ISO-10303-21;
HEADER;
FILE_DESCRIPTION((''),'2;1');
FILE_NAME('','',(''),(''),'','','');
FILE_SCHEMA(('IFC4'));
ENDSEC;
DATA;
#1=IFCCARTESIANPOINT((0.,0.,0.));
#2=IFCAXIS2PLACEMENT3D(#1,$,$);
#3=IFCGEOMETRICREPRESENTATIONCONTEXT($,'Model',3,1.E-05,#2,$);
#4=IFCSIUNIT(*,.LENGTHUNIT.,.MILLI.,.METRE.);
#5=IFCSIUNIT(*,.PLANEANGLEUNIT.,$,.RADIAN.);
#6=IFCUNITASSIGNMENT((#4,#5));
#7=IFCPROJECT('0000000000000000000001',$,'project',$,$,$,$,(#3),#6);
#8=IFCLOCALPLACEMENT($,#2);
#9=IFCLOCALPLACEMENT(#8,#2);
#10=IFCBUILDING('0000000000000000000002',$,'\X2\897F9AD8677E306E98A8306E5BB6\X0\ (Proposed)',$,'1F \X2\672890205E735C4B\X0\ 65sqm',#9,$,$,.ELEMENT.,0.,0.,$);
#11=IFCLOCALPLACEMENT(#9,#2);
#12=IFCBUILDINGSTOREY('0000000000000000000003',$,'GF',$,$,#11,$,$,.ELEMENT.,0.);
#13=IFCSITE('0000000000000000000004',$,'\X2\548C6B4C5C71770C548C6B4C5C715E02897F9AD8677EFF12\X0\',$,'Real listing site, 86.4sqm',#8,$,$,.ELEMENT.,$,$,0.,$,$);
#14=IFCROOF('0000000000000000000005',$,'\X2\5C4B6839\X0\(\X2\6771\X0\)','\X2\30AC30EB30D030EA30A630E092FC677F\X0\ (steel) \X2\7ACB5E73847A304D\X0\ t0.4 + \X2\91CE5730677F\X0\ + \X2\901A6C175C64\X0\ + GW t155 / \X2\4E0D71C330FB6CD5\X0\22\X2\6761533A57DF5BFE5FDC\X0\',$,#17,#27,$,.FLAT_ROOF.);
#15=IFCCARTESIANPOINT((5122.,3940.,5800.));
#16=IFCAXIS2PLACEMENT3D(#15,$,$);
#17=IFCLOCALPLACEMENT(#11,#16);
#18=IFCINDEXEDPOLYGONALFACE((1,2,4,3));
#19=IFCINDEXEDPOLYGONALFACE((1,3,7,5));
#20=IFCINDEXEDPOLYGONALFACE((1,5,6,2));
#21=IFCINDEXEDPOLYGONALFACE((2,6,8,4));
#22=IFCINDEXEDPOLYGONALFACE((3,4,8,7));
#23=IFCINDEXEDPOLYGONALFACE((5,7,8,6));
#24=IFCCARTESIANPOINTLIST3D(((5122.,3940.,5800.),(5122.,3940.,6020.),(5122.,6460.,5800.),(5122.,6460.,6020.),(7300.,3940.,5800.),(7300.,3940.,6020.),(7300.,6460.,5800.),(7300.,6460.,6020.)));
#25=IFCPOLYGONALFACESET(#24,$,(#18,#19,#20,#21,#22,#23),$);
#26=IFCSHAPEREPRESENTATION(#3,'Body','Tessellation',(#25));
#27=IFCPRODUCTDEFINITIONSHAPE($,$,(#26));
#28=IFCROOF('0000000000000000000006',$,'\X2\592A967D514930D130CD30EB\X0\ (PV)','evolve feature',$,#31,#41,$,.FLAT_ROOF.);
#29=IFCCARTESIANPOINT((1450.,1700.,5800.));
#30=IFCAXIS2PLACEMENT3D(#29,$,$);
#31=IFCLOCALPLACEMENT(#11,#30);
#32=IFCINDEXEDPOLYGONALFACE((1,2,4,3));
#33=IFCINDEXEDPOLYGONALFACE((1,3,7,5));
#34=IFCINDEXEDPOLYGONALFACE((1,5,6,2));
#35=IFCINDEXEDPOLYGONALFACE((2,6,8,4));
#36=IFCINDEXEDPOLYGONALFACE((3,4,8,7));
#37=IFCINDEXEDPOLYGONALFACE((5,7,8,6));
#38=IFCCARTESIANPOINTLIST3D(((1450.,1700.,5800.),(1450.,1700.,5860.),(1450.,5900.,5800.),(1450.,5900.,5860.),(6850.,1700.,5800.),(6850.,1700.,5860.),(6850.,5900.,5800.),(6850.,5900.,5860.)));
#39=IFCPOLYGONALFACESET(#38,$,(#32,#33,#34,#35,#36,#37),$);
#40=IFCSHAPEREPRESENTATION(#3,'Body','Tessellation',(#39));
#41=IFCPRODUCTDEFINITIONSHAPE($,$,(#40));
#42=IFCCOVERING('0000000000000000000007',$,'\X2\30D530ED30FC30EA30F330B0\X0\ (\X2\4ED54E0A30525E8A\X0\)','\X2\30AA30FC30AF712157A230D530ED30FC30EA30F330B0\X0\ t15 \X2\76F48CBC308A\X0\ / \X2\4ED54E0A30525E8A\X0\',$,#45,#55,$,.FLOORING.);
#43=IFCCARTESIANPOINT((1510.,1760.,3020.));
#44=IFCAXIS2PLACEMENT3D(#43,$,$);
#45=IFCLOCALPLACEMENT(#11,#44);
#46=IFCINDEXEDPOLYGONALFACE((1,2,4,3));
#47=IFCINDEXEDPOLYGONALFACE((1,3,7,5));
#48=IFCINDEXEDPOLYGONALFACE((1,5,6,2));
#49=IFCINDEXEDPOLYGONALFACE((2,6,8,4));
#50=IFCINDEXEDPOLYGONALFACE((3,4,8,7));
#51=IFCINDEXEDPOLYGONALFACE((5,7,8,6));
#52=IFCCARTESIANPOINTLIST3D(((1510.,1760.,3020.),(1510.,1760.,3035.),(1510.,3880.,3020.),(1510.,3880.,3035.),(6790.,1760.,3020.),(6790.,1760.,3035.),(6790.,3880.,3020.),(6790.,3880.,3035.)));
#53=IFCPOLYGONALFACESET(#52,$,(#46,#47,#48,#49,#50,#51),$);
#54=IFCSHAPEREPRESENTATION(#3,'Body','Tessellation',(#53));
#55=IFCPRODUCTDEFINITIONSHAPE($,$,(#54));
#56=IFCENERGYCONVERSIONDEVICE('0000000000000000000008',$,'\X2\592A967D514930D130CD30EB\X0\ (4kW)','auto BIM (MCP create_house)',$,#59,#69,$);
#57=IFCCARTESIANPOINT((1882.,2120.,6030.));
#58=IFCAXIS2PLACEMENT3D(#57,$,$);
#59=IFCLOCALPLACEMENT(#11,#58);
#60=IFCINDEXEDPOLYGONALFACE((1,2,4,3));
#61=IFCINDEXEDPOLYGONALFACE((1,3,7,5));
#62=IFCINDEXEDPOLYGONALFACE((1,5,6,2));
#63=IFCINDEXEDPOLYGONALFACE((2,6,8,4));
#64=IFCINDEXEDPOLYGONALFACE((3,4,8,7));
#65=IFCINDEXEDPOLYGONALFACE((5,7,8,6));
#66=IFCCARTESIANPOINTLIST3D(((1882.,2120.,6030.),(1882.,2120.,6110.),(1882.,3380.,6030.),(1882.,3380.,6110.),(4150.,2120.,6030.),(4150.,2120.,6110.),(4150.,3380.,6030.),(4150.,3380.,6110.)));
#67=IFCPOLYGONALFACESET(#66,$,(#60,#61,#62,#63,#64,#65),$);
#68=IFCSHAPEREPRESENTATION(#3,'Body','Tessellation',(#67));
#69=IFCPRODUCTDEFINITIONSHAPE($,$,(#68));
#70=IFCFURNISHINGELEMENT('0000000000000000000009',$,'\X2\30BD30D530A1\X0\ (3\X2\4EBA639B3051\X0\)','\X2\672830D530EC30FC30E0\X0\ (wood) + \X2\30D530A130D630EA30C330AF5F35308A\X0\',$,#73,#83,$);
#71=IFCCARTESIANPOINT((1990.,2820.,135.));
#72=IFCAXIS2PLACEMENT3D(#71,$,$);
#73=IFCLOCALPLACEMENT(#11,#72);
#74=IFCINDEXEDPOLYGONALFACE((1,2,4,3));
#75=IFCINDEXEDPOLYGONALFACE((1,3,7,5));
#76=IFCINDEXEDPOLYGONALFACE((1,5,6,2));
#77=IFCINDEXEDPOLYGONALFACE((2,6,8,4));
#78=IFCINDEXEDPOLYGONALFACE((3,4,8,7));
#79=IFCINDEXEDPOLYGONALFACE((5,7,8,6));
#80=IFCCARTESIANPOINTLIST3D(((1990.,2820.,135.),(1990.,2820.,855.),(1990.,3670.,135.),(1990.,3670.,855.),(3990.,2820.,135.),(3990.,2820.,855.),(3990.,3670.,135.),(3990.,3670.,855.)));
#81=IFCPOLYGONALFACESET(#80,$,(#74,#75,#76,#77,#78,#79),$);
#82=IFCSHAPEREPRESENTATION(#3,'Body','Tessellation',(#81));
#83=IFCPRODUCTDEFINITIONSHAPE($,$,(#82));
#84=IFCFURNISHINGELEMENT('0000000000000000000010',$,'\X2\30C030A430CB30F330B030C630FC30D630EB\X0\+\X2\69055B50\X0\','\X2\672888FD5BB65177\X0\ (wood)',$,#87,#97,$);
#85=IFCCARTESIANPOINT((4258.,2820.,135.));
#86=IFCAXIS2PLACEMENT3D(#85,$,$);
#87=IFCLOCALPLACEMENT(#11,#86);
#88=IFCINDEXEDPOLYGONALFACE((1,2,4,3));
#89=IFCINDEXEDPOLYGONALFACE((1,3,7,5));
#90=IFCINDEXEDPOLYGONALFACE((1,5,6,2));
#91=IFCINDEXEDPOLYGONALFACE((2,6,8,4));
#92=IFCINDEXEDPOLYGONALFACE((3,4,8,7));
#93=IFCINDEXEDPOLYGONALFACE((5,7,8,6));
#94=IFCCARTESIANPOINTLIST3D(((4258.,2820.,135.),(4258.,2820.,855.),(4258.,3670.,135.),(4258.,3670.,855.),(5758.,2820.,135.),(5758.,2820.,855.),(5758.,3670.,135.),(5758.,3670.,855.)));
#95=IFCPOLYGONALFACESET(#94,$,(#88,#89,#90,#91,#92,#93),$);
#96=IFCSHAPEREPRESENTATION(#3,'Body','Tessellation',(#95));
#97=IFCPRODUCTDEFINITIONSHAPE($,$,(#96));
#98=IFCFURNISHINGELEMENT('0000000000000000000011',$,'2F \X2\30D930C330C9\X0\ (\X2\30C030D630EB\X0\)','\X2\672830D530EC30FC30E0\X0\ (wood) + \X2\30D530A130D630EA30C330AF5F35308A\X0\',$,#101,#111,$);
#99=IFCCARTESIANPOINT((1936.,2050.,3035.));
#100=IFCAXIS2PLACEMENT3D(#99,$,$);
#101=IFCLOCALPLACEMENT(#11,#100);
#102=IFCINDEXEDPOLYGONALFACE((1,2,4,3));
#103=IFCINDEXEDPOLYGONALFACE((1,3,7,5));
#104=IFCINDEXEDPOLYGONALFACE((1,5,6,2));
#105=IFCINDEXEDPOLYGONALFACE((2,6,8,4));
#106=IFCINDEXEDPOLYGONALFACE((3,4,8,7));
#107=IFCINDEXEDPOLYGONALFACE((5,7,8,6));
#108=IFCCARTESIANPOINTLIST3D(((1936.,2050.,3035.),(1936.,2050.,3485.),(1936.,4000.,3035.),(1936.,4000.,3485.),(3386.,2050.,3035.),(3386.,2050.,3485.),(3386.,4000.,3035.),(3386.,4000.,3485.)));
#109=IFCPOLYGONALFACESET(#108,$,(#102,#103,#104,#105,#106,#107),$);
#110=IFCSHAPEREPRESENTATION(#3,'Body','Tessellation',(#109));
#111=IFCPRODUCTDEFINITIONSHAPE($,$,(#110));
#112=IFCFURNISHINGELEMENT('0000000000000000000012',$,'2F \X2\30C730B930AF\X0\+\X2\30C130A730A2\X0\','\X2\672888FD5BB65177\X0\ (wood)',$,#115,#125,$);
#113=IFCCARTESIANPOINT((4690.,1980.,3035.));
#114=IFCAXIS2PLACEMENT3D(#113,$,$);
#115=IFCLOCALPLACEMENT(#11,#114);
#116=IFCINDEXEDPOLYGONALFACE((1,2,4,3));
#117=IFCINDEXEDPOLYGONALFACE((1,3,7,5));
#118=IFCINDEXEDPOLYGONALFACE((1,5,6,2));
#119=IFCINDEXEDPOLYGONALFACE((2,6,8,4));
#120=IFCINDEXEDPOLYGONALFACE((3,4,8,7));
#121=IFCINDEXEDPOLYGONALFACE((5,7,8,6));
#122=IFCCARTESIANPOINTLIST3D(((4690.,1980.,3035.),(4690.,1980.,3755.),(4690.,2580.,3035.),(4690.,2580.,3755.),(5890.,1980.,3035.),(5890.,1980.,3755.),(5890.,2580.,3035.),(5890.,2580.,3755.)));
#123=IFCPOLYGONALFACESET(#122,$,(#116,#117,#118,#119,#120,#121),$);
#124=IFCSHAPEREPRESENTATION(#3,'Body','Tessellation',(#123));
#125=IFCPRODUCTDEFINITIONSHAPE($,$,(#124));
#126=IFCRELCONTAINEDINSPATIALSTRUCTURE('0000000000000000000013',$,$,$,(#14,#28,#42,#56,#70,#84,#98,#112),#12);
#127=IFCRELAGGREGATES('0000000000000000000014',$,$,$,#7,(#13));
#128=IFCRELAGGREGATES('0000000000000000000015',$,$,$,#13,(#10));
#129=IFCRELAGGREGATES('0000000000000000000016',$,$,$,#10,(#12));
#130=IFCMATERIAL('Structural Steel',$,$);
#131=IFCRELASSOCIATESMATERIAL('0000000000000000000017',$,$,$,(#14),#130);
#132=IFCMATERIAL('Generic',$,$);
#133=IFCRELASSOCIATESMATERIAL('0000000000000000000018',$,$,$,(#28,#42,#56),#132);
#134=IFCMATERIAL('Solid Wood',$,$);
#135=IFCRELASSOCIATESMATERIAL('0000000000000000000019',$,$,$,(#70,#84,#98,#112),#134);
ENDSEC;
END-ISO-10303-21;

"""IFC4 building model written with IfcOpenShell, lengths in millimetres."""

from ifc_helpers import new_model, si_unit, frame, frame_2d, origin, place, context, project, spatial, rectangle, extrude, material, element, save


model = new_model("IFC4")

# Units and contexts
model_context = context("Model", 3, precision=1e-05, world=origin())
ifc_project = project(units=[si_unit("LENGTHUNIT", "METRE", prefix="MILLI"), si_unit("PLANEANGLEUNIT", "RADIAN")], contexts=[model_context])

# Site, building, storey
site_placement = place(None, origin())
site = spatial("IfcSite", under=ifc_project, at=site_placement, Name="和歌山県和歌山市西高松２", ObjectType="Real listing site, 86.4sqm", CompositionType="ELEMENT", RefElevation=0.0)
building_placement = place(site_placement, origin())
building = spatial("IfcBuilding", under=site, at=building_placement, Name="西高松の風の家 (Proposed)", ObjectType="1F 木造平屋 65sqm", CompositionType="ELEMENT", ElevationOfRefHeight=0.0, ElevationOfTerrain=0.0)
storey_placement = place(building_placement, origin())
storey = spatial("IfcBuildingStorey", under=building, at=storey_placement, Name="GF", CompositionType="ELEMENT", Elevation=0.0)

# Shared definitions
ifc_material_1 = material(Name="Solid Wood")

# Roofs
ifc_material_2 = material(Name="Structural Steel")
roof_1_placement = place(storey_placement, frame((5122.0, 3940.0, 5800.0)))
element("IfcRoof", 1, at=roof_1_placement, inside=storey, material=ifc_material_2, Name="屋根(東)", Description="ガルバリウム鋼板 (steel) 立平葺き t0.4 + 野地板 + 通気層 + GW t155 / 不燃・法22条区域対応", PredefinedType="FLAT_ROOF", context=model_context, shape_type="SweptSolid", body=[
    extrude(rectangle(XDim=2178.0, YDim=2520.0, at=frame_2d((1089.0, 1260.0))), frame((5122.0, 3940.0, 5800.0)), (0.0, 0.0, 1.0), 220.0),
])
ifc_material_3 = material(Name="Generic")
roof_2_placement = place(storey_placement, frame((1450.0, 1700.0, 5800.0)))
element("IfcRoof", 2, at=roof_2_placement, inside=storey, material=ifc_material_3, Name="太陽光パネル (PV)", Description="evolve feature", PredefinedType="FLAT_ROOF", context=model_context, shape_type="SweptSolid", body=[
    extrude(rectangle(XDim=5400.0, YDim=4200.0, at=frame_2d((2700.0, 2100.0))), frame((1450.0, 1700.0, 5800.0)), (0.0, 0.0, 1.0), 60.0),
])

# Covering
covering_placement = place(storey_placement, frame((1510.0, 1760.0, 3020.0)))
element("IfcCovering", 3, at=covering_placement, inside=storey, material=ifc_material_3, Name="フローリング (仕上げ床)", Description="オーク無垢フローリング t15 直貼り / 仕上げ床", PredefinedType="FLOORING", context=model_context, shape_type="SweptSolid", body=[
    extrude(rectangle(XDim=5280.0, YDim=2120.0, at=frame_2d((2640.0, 1060.0))), frame((1510.0, 1760.0, 3020.0)), (0.0, 0.0, 1.0), 15.0),
])

# Energy conversion device
energy_conversion_device_placement = place(storey_placement, frame((1882.0, 2120.0, 6030.0)))
element("IfcEnergyConversionDevice", 4, at=energy_conversion_device_placement, inside=storey, material=ifc_material_3, Name="太陽光パネル (4kW)", Description="auto BIM (MCP create_house)", context=model_context, shape_type="SweptSolid", body=[
    extrude(rectangle(XDim=2268.0, YDim=1260.0, at=frame_2d((1134.0, 630.0))), frame((1882.0, 2120.0, 6030.0)), (0.0, 0.0, 1.0), 80.0),
])

# Furnishing elements
furnishing_1_placement = place(storey_placement, frame((1990.0, 2820.0, 135.0)))
element("IfcFurnishingElement", 5, at=furnishing_1_placement, inside=storey, material=ifc_material_1, Name="ソファ (3人掛け)", Description="木フレーム (wood) + ファブリック張り", context=model_context, shape_type="SweptSolid", body=[
    extrude(rectangle(XDim=2000.0, YDim=850.0, at=frame_2d((1000.0, 425.0))), frame((1990.0, 2820.0, 135.0)), (0.0, 0.0, 1.0), 720.0),
])
furnishing_2_placement = place(storey_placement, frame((4258.0, 2820.0, 135.0)))
element("IfcFurnishingElement", 6, at=furnishing_2_placement, inside=storey, material=ifc_material_1, Name="ダイニングテーブル+椅子", Description="木製家具 (wood)", context=model_context, shape_type="SweptSolid", body=[
    extrude(rectangle(XDim=1500.0, YDim=850.0, at=frame_2d((750.0, 425.0))), frame((4258.0, 2820.0, 135.0)), (0.0, 0.0, 1.0), 720.0),
])
furnishing_3_placement = place(storey_placement, frame((1936.0, 2050.0, 3035.0)))
element("IfcFurnishingElement", 7, at=furnishing_3_placement, inside=storey, material=ifc_material_1, Name="2F ベッド (ダブル)", Description="木フレーム (wood) + ファブリック張り", context=model_context, shape_type="SweptSolid", body=[
    extrude(rectangle(XDim=1450.0, YDim=1950.0, at=frame_2d((725.0, 975.0))), frame((1936.0, 2050.0, 3035.0)), (0.0, 0.0, 1.0), 450.0),
])
furnishing_4_placement = place(storey_placement, frame((4690.0, 1980.0, 3035.0)))
element("IfcFurnishingElement", 8, at=furnishing_4_placement, inside=storey, material=ifc_material_1, Name="2F デスク+チェア", Description="木製家具 (wood)", context=model_context, shape_type="SweptSolid", body=[
    extrude(rectangle(XDim=1200.0, YDim=600.0, at=frame_2d((600.0, 300.0))), frame((4690.0, 1980.0, 3035.0)), (0.0, 0.0, 1.0), 720.0),
])

save(model, "model.ifc")
